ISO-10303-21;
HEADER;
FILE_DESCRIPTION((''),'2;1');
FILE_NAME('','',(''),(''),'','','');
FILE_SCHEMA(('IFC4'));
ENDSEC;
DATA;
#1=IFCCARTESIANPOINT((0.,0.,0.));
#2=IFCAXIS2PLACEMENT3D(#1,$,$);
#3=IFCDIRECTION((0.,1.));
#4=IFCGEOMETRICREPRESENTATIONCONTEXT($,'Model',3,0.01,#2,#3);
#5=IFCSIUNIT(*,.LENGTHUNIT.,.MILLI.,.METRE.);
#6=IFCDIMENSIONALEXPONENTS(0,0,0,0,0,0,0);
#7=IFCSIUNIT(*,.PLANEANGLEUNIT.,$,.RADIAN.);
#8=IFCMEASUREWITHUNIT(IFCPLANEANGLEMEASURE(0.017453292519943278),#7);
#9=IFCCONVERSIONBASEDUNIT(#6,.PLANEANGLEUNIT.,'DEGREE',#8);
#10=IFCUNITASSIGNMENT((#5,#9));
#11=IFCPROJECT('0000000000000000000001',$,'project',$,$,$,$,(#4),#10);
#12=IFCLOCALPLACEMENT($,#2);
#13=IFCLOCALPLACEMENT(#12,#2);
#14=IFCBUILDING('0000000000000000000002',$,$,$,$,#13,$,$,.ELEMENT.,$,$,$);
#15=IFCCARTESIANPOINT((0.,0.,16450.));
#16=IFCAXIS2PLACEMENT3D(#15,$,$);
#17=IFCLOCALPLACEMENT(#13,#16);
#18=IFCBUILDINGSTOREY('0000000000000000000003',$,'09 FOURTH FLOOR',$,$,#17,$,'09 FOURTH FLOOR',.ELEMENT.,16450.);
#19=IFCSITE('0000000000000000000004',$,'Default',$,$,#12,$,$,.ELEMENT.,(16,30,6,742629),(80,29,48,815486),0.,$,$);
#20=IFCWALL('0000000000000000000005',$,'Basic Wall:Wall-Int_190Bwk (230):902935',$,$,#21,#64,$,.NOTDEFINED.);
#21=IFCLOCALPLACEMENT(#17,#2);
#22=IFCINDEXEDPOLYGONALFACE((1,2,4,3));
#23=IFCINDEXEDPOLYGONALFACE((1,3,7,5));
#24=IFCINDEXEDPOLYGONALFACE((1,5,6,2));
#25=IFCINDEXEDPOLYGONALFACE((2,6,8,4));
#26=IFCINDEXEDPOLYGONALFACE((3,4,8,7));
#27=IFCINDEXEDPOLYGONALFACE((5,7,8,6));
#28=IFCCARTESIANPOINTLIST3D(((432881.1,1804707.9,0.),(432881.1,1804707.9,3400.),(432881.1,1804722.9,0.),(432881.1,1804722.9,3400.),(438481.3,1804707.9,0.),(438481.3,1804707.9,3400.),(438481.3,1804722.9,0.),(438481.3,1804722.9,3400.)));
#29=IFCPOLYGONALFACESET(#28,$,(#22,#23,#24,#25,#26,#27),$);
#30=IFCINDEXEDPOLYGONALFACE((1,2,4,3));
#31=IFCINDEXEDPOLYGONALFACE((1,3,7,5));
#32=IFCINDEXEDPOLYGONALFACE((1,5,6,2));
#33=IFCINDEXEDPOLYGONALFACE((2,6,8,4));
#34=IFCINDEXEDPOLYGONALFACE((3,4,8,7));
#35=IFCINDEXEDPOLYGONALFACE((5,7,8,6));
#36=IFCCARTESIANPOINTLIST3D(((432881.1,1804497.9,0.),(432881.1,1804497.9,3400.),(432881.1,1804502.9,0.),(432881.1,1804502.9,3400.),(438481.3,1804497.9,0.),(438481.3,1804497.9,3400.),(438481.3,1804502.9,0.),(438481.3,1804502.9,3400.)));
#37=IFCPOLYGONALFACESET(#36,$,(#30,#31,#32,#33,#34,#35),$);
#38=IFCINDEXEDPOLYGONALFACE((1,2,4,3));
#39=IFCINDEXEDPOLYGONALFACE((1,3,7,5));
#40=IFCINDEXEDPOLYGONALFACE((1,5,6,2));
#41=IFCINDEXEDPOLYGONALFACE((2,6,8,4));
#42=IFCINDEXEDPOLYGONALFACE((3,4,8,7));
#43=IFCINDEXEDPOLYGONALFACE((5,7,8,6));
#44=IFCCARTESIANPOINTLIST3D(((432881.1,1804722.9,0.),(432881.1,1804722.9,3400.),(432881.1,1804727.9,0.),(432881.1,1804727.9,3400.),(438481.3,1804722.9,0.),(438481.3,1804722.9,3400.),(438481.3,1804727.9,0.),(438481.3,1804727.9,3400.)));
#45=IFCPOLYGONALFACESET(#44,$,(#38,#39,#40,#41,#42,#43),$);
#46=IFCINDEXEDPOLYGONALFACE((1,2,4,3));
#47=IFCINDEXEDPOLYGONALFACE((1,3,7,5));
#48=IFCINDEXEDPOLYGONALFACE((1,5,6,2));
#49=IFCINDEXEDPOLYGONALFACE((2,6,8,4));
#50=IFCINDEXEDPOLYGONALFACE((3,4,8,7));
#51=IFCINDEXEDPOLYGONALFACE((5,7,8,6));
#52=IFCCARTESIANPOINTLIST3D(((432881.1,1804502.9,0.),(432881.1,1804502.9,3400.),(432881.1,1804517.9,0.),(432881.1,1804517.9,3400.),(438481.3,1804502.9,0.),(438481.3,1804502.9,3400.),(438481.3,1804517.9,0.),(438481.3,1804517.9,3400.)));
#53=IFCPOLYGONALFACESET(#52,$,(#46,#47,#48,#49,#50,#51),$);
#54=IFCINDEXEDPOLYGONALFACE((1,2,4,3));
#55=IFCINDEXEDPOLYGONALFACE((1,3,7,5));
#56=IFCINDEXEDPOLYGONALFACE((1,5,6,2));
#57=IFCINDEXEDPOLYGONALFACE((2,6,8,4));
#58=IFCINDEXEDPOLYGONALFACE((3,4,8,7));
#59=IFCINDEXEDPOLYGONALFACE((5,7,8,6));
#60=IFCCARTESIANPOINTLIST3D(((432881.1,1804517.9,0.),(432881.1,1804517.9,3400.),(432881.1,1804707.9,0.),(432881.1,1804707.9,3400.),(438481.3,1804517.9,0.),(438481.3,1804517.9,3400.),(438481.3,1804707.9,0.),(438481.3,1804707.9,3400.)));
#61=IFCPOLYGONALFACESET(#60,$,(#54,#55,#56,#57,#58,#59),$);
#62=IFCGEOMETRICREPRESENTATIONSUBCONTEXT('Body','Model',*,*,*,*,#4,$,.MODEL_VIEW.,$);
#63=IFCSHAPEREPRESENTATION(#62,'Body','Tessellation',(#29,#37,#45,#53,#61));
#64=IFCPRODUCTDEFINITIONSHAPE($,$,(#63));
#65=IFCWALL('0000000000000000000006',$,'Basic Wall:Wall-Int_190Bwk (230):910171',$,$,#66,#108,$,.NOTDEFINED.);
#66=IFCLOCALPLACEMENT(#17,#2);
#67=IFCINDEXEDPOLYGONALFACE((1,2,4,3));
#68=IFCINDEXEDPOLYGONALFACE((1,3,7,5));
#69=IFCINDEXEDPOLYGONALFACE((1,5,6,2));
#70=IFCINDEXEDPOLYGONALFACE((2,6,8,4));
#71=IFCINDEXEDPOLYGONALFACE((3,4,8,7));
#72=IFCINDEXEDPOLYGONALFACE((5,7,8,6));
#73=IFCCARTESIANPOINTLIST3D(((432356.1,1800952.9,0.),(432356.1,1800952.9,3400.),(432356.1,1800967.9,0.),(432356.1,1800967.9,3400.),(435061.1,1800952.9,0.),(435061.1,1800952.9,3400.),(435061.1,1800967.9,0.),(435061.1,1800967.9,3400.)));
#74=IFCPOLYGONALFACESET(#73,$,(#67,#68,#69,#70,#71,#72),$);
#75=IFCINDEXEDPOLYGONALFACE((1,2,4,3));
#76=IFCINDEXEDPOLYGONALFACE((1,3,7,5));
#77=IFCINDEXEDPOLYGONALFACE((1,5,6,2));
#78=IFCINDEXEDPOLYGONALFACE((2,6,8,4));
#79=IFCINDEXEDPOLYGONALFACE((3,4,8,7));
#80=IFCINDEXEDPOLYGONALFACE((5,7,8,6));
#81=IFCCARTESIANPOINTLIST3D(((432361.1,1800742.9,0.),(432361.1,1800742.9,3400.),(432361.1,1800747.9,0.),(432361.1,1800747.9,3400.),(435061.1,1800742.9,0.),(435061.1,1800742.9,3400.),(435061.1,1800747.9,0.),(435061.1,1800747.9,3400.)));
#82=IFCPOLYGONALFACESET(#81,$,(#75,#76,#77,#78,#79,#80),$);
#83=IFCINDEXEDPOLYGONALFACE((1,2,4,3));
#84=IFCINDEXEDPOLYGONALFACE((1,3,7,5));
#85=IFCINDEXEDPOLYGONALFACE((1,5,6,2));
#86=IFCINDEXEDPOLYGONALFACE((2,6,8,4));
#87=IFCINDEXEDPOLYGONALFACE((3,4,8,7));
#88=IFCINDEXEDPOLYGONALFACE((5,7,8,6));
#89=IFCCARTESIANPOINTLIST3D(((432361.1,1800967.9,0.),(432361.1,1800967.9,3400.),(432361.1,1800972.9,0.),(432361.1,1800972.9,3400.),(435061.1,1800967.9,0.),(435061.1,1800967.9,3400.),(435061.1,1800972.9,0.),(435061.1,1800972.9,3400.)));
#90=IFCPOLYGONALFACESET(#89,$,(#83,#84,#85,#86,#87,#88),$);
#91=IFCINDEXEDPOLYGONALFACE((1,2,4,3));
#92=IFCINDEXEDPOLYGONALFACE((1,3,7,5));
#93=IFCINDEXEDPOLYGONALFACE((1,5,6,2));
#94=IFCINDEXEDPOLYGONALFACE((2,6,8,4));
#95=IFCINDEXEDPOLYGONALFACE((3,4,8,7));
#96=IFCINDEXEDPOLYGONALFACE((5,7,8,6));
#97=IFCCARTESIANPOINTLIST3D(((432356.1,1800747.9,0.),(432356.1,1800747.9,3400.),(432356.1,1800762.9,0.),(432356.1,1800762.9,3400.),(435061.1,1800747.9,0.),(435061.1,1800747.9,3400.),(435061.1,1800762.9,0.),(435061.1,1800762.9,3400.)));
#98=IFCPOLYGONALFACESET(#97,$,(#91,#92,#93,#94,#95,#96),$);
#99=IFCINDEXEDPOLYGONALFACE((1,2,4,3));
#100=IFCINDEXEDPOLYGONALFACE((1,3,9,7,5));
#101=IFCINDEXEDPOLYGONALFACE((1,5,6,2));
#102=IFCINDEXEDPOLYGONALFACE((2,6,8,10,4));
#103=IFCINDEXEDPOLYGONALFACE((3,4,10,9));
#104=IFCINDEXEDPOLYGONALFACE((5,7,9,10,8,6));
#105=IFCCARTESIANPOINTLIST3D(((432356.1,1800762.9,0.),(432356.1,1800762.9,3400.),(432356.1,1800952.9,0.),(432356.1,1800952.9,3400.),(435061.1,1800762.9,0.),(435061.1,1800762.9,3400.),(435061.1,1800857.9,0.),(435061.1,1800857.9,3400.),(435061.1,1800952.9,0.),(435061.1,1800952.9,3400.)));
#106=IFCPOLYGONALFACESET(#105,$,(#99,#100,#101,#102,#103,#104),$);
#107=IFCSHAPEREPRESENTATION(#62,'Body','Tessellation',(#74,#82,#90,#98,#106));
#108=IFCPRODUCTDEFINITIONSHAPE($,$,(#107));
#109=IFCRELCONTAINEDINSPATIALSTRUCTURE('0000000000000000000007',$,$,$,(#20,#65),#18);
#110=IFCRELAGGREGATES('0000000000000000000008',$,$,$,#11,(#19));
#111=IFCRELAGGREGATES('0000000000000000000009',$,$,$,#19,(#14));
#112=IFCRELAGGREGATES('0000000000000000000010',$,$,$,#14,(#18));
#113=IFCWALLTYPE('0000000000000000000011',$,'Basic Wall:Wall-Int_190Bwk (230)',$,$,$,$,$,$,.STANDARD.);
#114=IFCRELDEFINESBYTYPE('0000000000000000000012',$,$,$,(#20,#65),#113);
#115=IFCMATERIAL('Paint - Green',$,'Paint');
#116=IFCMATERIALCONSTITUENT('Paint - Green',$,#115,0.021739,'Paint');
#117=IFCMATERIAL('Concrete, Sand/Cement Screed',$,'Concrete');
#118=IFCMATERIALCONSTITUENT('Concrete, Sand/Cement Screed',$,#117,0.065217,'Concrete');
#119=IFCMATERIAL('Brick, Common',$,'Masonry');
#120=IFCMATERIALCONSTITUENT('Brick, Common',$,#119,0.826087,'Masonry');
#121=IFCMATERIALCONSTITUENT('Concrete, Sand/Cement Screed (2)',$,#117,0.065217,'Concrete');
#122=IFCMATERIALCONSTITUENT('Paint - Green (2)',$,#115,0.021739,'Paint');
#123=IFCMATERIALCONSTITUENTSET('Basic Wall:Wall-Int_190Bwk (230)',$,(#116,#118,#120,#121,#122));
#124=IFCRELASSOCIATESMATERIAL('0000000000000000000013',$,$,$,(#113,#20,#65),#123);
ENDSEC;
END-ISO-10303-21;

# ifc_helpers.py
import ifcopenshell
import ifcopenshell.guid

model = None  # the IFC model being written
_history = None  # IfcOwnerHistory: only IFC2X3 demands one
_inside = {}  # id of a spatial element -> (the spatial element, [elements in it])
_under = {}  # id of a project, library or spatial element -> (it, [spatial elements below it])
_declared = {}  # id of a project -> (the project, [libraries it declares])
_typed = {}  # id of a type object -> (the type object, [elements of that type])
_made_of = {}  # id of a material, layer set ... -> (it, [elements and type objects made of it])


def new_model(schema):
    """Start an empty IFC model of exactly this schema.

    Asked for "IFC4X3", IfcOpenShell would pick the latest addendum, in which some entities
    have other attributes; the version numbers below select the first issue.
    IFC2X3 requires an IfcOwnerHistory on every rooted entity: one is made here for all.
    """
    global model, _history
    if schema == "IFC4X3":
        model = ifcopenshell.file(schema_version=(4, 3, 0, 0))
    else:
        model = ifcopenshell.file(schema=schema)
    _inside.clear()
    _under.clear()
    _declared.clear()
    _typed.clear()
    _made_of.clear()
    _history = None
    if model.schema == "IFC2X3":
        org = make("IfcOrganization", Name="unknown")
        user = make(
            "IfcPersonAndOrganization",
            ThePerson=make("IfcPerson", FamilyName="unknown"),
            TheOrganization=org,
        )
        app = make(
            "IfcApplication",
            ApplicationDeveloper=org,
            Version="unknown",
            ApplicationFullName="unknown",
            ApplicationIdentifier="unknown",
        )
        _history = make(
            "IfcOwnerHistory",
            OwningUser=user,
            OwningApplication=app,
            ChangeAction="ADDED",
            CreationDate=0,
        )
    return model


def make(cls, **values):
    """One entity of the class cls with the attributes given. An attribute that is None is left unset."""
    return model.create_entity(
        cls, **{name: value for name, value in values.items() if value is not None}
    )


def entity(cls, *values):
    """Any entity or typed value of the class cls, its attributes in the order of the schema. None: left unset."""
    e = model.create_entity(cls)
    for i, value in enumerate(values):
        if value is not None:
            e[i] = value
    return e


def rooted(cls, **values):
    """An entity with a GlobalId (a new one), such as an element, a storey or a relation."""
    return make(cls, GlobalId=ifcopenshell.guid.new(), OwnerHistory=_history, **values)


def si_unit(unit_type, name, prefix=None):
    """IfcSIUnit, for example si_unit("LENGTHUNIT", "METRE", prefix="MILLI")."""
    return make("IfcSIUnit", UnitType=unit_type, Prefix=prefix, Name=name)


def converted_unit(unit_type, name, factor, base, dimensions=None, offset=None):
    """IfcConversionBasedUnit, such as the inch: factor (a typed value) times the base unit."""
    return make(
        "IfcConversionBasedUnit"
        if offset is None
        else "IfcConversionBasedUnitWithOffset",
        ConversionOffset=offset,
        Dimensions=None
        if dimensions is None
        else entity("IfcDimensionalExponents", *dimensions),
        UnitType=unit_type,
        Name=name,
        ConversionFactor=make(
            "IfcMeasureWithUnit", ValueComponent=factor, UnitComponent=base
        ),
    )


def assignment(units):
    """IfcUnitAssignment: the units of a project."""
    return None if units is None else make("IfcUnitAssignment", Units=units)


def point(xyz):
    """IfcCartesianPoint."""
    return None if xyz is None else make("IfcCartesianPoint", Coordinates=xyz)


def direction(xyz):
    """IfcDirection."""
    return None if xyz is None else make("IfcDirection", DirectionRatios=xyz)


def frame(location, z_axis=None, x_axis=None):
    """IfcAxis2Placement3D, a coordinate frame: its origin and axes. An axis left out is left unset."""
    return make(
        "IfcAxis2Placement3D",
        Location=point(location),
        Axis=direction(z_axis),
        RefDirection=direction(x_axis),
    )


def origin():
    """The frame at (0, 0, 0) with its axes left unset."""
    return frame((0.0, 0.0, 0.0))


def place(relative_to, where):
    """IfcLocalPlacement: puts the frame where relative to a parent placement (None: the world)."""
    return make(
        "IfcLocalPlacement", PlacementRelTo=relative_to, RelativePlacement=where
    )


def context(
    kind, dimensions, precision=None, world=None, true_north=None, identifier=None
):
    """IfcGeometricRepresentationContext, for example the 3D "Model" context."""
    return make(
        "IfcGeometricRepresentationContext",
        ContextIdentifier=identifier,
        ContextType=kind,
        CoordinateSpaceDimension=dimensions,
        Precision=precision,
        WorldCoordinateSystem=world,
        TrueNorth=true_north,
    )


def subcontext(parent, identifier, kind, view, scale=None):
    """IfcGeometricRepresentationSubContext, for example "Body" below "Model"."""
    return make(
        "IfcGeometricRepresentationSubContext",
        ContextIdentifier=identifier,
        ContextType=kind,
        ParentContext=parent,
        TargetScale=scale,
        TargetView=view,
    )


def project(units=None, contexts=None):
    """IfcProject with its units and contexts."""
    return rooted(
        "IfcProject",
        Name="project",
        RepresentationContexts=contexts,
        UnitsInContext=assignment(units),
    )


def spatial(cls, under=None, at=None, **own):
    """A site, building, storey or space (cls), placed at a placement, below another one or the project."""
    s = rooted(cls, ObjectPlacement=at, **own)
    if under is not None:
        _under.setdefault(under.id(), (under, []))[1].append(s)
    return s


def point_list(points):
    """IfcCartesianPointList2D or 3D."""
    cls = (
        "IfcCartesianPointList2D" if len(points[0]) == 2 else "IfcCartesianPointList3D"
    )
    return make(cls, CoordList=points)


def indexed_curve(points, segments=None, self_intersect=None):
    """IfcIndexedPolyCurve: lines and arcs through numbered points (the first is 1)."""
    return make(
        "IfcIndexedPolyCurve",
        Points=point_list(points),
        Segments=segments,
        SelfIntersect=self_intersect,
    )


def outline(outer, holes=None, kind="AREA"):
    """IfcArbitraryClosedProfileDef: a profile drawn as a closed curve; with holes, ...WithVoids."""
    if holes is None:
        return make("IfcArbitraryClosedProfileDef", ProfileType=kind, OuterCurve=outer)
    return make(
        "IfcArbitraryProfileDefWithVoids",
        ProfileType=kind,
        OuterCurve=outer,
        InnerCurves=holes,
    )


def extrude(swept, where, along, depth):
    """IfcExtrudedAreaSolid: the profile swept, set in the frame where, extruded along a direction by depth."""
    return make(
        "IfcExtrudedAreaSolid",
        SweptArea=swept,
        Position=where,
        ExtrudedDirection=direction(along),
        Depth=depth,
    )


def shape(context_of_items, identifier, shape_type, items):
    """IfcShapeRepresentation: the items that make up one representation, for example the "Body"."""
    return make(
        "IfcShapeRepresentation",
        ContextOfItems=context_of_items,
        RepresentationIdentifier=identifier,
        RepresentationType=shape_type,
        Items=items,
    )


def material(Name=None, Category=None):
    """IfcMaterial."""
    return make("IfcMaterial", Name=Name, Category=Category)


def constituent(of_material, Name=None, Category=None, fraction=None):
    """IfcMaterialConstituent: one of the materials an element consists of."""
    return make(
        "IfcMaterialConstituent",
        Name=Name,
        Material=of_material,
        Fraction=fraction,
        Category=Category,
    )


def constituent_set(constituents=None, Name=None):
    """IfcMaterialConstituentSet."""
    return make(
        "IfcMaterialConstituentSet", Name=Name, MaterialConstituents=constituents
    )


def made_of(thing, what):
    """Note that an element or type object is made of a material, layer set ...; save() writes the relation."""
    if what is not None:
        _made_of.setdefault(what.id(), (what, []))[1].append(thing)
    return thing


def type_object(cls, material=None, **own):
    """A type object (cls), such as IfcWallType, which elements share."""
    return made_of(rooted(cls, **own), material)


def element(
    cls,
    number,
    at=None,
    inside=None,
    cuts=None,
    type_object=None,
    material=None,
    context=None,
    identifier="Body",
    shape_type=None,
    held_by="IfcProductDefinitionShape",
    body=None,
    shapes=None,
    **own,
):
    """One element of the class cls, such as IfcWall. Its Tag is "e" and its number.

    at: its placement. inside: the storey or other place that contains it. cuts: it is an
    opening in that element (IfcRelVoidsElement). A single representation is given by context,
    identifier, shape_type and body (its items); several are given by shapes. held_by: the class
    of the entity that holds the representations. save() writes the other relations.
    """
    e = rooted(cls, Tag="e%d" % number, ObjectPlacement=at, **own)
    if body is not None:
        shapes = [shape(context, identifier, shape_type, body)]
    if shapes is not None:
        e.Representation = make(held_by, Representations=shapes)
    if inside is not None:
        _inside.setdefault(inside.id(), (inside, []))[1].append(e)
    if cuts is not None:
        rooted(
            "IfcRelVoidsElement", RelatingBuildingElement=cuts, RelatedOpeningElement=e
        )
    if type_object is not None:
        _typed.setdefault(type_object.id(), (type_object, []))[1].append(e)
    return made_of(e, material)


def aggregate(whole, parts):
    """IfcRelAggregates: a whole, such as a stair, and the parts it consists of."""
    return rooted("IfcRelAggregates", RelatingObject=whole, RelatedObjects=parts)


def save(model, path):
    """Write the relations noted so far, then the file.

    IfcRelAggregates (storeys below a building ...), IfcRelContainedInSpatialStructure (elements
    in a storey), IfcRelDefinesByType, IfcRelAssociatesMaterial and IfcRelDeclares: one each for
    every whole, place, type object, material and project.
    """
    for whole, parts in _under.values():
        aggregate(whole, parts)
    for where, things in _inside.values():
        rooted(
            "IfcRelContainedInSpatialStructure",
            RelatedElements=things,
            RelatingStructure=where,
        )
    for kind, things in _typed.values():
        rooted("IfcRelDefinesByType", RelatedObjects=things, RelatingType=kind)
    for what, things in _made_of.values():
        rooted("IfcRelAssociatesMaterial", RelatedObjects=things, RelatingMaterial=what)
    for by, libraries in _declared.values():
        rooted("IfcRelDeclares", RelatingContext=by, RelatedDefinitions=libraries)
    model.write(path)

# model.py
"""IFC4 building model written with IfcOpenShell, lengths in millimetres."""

from ifc_helpers import new_model, entity, si_unit, converted_unit, direction, frame, origin, place, context, subcontext, project, spatial, indexed_curve, outline, extrude, material, constituent, constituent_set, type_object, element, save


model = new_model("IFC4")

# Units and contexts
model_context = context("Model", 3, precision=0.01, world=origin(), true_north=direction((0.0, 1.0)))
body_context = subcontext(model_context, "Body", "Model", "MODEL_VIEW")
ifc_project = project(units=[si_unit("LENGTHUNIT", "METRE", prefix="MILLI"), converted_unit("PLANEANGLEUNIT", "DEGREE", entity("IfcPlaneAngleMeasure", 0.017453292519943278), si_unit("PLANEANGLEUNIT", "RADIAN"), dimensions=[0, 0, 0, 0, 0, 0, 0])], contexts=[model_context])

# Site, building, storey
site_placement = place(None, origin())
site = spatial("IfcSite", under=ifc_project, at=site_placement, Name="Default", CompositionType="ELEMENT", RefLatitude=(16, 30, 6, 742629), RefLongitude=(80, 29, 48, 815486), RefElevation=0.0)
building_placement = place(site_placement, origin())
building = spatial("IfcBuilding", under=site, at=building_placement, CompositionType="ELEMENT")
storey_placement = place(building_placement, frame((0.0, 0.0, 16450.0)))
storey = spatial("IfcBuildingStorey", under=building, at=storey_placement, Name="09 FOURTH FLOOR", LongName="09 FOURTH FLOOR", CompositionType="ELEMENT", Elevation=16450.0)

# Shared definitions
ifc_material_1 = material(Name="Concrete, Sand/Cement Screed", Category="Concrete")
ifc_material_2 = material(Name="Brick, Common", Category="Masonry")

# Shared definitions
ifc_material_3 = material(Name="Paint - Green", Category="Paint")

# Walls
ifc_constituent_1 = constituent(ifc_material_3, Name="Paint - Green", Category="Paint", fraction=0.021739)
ifc_constituent_2 = constituent(ifc_material_1, Name="Concrete, Sand/Cement Screed", Category="Concrete", fraction=0.065217)
ifc_constituent_3 = constituent(ifc_material_2, Name="Brick, Common", Category="Masonry", fraction=0.826087)
ifc_constituent_4 = constituent(ifc_material_1, Name="Concrete, Sand/Cement Screed (2)", Category="Concrete", fraction=0.065217)
ifc_constituent_5 = constituent(ifc_material_3, Name="Paint - Green (2)", Category="Paint", fraction=0.021739)
ifc_constituent_set_1 = constituent_set(constituents=[ifc_constituent_1, ifc_constituent_2, ifc_constituent_3, ifc_constituent_4, ifc_constituent_5], Name="Basic Wall:Wall-Int_190Bwk (230)")
wall_type_1 = type_object("IfcWallType", Name="Basic Wall:Wall-Int_190Bwk (230)", PredefinedType="STANDARD", material=ifc_constituent_set_1)
wall_1_placement = place(storey_placement, frame((432881.1, 1804612.9, 0.0)))
element("IfcWall", 1, at=wall_1_placement, inside=storey, type_object=wall_type_1, material=ifc_constituent_set_1, Name="Basic Wall:Wall-Int_190Bwk (230):902935", PredefinedType="NOTDEFINED", context=body_context, shape_type="SweptSolid", body=[
    extrude(outline(indexed_curve([(-2800.1, -7.5), (2800.1, -7.5), (2800.1, 7.5), (-2800.1, 7.5), (-2800.1, -7.5)], self_intersect=False)), frame((2800.1, 102.5, 0.0)), (0.0, 0.0, 1.0), 3400.0),
    extrude(outline(indexed_curve([(-2.5, -2800.1), (2.5, -2800.1), (2.5, 2800.1), (-2.5, 2800.1), (-2.5, -2800.1)], self_intersect=False)), frame((2800.1, -112.5, 0.0), z_axis=(0.0, 0.0, 1.0), x_axis=(0.0, 1.0, 0.0)), (0.0, 0.0, 1.0), 3400.0),
    extrude(outline(indexed_curve([(-2.5, -2800.1), (2.5, -2800.1), (2.5, 2800.1), (-2.5, 2800.1), (-2.5, -2800.1)], self_intersect=False)), frame((2800.1, 112.5, 0.0), z_axis=(0.0, 0.0, 1.0), x_axis=(0.0, -1.0, 0.0)), (0.0, 0.0, 1.0), 3400.0),
    extrude(outline(indexed_curve([(-2800.1, -7.5), (2800.1, -7.5), (2800.1, 7.5), (-2800.1, 7.5), (-2800.1, -7.5)], self_intersect=False)), frame((2800.1, -102.5, 0.0)), (0.0, 0.0, 1.0), 3400.0),
    extrude(outline(indexed_curve([(-2800.1, -95.0), (2800.1, -95.0), (2800.1, 95.0), (-2800.1, 95.0), (-2800.1, -95.0)], self_intersect=False)), frame((2800.1, 0.0, 0.0)), (0.0, 0.0, 1.0), 3400.0),
])
wall_2_placement = place(storey_placement, frame((432361.1, 1800857.9, 0.0)))
element("IfcWall", 2, at=wall_2_placement, inside=storey, type_object=wall_type_1, material=ifc_constituent_set_1, Name="Basic Wall:Wall-Int_190Bwk (230):910171", PredefinedType="NOTDEFINED", context=body_context, shape_type="SweptSolid", body=[
    extrude(outline(indexed_curve([(-1352.5, -7.5), (1352.5, -7.5), (1352.5, 7.5), (-1352.5, 7.5), (-1352.5, -7.5)], self_intersect=False)), frame((1347.5, 102.5, 0.0)), (0.0, 0.0, 1.0), 3400.0),
    extrude(outline(indexed_curve([(-2.5, -1350.0), (2.5, -1350.0), (2.5, 1350.0), (-2.5, 1350.0), (-2.5, -1350.0)], self_intersect=False)), frame((1350.0, -112.5, 0.0), z_axis=(0.0, 0.0, 1.0), x_axis=(0.0, 1.0, 0.0)), (0.0, 0.0, 1.0), 3400.0),
    extrude(outline(indexed_curve([(-2.5, -1350.0), (2.5, -1350.0), (2.5, 1350.0), (-2.5, 1350.0), (-2.5, -1350.0)], self_intersect=False)), frame((1350.0, 112.5, 0.0), z_axis=(0.0, 0.0, 1.0), x_axis=(0.0, -1.0, 0.0)), (0.0, 0.0, 1.0), 3400.0),
    extrude(outline(indexed_curve([(-1352.5, -7.5), (1352.5, -7.5), (1352.5, 7.5), (-1352.5, 7.5), (-1352.5, -7.5)], self_intersect=False)), frame((1347.5, -102.5, 0.0)), (0.0, 0.0, 1.0), 3400.0),
    extrude(outline(indexed_curve([(-1623.0, -95.0), (1082.0, -95.0), (1082.0, 0.0), (1082.0, 95.0), (-1623.0, 95.0), (-1623.0, -95.0)], self_intersect=False)), frame((1618.0, 0.0, 0.0)), (0.0, 0.0, 1.0), 3400.0),
])

save(model, "model.ifc")
